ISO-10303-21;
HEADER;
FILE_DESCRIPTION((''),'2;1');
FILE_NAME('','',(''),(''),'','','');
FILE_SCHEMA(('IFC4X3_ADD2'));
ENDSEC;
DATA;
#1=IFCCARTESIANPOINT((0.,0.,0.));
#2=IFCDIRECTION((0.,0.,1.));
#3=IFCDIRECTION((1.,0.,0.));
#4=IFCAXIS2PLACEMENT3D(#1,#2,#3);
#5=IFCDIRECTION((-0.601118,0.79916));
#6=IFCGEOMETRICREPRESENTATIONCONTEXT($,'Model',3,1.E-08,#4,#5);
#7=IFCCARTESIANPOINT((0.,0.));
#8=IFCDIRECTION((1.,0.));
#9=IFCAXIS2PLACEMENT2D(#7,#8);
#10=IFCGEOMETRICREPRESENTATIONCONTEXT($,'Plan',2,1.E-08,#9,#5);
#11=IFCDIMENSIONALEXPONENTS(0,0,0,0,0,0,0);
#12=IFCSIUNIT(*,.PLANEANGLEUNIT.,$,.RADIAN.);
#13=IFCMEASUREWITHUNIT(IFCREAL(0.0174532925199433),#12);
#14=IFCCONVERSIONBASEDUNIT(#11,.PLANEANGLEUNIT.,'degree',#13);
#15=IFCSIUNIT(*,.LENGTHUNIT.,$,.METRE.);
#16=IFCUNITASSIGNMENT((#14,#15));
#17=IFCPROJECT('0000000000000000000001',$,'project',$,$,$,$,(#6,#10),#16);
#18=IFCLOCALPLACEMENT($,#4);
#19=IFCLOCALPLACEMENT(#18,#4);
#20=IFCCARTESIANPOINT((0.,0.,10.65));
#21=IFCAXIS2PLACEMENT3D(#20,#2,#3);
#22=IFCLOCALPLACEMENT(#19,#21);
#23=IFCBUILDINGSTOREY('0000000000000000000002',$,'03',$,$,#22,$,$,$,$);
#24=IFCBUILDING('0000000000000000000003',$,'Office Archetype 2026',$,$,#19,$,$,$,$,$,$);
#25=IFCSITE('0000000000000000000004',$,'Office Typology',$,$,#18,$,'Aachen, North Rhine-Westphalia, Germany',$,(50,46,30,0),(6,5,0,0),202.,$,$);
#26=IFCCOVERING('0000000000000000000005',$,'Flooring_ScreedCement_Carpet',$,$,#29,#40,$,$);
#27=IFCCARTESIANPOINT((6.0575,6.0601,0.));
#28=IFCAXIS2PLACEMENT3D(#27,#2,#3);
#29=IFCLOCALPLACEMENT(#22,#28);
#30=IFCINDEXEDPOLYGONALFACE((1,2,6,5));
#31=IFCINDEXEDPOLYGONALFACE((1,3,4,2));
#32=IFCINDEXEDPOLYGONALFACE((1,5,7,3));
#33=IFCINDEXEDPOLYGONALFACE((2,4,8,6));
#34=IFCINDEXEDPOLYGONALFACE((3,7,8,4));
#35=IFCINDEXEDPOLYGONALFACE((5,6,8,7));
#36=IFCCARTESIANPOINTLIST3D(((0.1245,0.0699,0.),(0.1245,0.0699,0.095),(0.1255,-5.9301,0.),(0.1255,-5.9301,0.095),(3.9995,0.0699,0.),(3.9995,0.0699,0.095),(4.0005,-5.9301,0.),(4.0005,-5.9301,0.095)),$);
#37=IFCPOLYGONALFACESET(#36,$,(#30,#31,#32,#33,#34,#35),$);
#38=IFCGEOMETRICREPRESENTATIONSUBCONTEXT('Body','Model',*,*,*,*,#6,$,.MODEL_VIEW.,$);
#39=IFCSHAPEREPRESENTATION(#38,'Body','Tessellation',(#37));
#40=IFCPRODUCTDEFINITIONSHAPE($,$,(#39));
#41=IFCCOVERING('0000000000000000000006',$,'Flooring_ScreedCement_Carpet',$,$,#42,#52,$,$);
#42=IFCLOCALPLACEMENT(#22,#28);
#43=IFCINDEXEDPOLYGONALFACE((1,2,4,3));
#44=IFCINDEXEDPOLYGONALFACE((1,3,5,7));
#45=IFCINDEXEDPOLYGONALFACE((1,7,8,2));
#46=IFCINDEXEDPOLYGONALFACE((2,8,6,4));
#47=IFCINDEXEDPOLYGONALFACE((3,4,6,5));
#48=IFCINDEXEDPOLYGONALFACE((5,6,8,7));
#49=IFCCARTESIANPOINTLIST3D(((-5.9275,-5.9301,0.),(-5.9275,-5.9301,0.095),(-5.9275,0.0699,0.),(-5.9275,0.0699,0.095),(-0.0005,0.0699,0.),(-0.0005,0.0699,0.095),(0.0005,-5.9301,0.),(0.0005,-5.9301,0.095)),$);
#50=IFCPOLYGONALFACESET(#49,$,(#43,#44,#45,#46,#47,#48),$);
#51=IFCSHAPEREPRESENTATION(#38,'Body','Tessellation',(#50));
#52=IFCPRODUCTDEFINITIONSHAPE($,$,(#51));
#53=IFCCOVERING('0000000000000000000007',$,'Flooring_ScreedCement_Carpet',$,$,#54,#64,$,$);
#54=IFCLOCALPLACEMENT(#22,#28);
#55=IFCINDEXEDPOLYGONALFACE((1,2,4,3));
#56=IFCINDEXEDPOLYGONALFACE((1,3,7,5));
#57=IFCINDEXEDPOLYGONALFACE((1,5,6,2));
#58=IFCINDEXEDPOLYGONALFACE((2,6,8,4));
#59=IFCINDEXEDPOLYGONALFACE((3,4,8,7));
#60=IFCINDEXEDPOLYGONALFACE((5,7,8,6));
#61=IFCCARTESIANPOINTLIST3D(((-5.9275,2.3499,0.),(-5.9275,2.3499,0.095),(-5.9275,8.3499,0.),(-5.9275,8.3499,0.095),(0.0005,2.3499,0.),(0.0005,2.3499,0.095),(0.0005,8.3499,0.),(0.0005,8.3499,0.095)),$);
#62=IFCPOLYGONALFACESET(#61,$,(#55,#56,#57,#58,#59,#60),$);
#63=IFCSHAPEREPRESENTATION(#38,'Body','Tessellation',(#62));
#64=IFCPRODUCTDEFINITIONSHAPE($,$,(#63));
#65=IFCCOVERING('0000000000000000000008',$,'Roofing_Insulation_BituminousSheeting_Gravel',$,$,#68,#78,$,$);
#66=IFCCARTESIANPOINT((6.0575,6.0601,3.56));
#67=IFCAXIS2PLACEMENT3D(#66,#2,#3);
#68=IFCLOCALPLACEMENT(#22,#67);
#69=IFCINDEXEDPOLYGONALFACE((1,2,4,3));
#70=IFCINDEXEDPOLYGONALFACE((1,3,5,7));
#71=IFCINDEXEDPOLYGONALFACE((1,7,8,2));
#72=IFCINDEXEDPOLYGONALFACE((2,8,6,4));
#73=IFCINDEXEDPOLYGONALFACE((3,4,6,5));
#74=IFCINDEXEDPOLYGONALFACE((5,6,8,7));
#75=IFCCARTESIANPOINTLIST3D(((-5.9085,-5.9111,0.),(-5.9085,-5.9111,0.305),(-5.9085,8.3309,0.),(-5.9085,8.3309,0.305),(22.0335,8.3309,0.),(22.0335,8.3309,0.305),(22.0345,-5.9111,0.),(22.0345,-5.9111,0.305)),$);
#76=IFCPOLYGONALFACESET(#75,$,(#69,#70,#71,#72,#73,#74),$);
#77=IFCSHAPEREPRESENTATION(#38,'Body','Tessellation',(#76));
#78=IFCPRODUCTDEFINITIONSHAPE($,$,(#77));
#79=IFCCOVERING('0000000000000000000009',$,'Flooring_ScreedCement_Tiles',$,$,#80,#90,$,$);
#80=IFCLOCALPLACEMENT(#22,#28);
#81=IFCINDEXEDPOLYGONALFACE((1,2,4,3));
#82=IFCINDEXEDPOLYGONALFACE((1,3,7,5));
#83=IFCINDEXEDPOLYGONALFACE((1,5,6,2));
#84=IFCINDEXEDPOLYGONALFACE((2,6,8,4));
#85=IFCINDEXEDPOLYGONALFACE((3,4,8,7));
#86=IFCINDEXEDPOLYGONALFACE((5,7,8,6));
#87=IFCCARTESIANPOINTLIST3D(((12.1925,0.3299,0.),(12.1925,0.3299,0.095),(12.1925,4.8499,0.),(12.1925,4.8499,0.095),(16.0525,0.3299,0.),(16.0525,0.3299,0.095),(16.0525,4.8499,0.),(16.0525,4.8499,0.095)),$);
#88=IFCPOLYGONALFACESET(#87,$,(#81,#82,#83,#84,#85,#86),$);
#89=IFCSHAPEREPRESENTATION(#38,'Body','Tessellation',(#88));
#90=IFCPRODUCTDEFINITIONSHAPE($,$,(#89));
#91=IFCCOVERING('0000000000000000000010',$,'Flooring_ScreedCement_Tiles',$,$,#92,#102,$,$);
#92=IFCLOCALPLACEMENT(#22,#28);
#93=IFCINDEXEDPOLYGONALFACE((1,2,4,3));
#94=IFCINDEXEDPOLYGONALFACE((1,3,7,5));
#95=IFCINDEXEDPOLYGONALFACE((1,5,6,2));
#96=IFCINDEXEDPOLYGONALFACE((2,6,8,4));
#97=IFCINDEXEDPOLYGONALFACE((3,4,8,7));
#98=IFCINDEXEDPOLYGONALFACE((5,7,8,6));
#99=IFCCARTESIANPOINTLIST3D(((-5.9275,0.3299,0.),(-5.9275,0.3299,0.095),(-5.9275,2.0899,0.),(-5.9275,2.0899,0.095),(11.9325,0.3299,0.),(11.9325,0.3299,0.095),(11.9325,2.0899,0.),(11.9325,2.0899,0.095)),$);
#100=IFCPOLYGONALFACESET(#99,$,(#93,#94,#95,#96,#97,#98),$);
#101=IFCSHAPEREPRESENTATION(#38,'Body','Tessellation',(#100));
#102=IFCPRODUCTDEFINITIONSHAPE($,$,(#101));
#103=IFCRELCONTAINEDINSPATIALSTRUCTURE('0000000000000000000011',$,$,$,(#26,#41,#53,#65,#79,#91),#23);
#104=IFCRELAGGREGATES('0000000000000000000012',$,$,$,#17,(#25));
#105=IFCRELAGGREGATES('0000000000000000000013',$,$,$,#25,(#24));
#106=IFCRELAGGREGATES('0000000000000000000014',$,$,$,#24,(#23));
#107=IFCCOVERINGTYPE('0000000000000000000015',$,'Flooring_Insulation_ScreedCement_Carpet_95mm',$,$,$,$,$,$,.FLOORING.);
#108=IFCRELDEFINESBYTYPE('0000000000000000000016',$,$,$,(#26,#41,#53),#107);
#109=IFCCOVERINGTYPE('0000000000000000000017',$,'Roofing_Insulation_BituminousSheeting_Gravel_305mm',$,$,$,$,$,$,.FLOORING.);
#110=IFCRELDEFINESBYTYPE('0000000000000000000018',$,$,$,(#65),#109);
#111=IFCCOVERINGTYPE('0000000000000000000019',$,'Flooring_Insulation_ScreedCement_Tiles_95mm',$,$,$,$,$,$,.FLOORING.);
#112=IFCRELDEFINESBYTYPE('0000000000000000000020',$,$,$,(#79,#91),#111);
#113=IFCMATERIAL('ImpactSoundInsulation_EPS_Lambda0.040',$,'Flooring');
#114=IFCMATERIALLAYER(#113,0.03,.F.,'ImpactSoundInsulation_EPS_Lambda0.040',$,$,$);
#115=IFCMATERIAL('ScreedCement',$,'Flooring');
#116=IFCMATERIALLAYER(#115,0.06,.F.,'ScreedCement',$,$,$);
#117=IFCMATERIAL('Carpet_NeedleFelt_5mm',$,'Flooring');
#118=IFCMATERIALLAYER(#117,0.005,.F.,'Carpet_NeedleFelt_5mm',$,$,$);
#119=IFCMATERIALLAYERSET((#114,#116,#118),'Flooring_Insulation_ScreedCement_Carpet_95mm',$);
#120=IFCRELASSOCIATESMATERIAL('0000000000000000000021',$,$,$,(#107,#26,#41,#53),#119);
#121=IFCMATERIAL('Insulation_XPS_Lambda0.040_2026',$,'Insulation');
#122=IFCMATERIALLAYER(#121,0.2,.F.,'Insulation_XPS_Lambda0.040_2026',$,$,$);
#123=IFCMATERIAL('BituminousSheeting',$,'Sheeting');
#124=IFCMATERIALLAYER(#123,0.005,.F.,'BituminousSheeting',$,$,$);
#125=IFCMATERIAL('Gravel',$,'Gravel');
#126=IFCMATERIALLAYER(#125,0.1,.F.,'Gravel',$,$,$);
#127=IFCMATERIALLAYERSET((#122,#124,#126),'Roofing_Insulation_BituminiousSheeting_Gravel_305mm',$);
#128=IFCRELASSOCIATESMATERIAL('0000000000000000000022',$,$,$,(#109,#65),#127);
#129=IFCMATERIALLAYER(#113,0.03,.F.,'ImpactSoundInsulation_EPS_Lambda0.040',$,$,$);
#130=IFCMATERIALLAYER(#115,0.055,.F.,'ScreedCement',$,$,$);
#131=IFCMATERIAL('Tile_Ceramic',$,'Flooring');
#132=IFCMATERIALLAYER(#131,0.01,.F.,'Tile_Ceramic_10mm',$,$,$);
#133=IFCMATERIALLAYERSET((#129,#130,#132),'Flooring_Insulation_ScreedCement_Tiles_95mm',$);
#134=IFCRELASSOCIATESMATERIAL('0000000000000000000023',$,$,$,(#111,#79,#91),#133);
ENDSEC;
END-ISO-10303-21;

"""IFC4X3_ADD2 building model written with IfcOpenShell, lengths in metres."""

from ifc_helpers import new_model, entity, si_unit, converted_unit, direction, frame, origin_with_axes, origin_2d_with_axis, place, context, subcontext, project, spatial, line, indexed_curve, outline, extrude, material, layer, layer_set, layer_usage, type_object, element, save


model = new_model("IFC4X3_ADD2")

# Units and contexts
model_context = context("Model", 3, precision=1e-08, world=origin_with_axes(), true_north=direction((-0.601118, 0.79916)))
plan_context = context("Plan", 2, precision=1e-08, world=origin_2d_with_axis(), true_north=direction((-0.601118, 0.79916)))
body_context = subcontext(model_context, "Body", "Model", "MODEL_VIEW")
ifc_project = project(units=[converted_unit("PLANEANGLEUNIT", "degree", entity("IfcReal", 0.0174532925199433), si_unit("PLANEANGLEUNIT", "RADIAN"), dimensions=[0, 0, 0, 0, 0, 0, 0]), si_unit("LENGTHUNIT", "METRE")], contexts=[model_context, plan_context])

# Site, building, storey
site_placement = place(None, origin_with_axes())
site = spatial("IfcSite", under=ifc_project, at=site_placement, Name="Office Typology", LongName="Aachen, North Rhine-Westphalia, Germany", RefLatitude=(50, 46, 30, 0), RefLongitude=(6, 5, 0, 0), RefElevation=202.0)
building_placement = place(site_placement, origin_with_axes())
building = spatial("IfcBuilding", under=site, at=building_placement, Name="Office Archetype 2026")
storey_placement = place(building_placement, frame((0.0, 0.0, 10.65), z_axis=(0.0, 0.0, 1.0), x_axis=(1.0, 0.0, 0.0)))
storey = spatial("IfcBuildingStorey", under=building, at=storey_placement, Name="03")

# Coverings
ifc_material_1 = material(Name="ImpactSoundInsulation_EPS_Lambda0.040", Category="Flooring")
ifc_layer_1 = layer(ifc_material_1, 0.03, ventilated=False, Name="ImpactSoundInsulation_EPS_Lambda0.040")
ifc_material_2 = material(Name="ScreedCement", Category="Flooring")
ifc_layer_2 = layer(ifc_material_2, 0.06, ventilated=False, Name="ScreedCement")
ifc_material_3 = material(Name="Carpet_NeedleFelt_5mm", Category="Flooring")
ifc_layer_3 = layer(ifc_material_3, 0.005, ventilated=False, Name="Carpet_NeedleFelt_5mm")
ifc_layer_set_1 = layer_set([ifc_layer_1, ifc_layer_2, ifc_layer_3], Name="Flooring_Insulation_ScreedCement_Carpet_95mm")
ifc_layer_usage_1 = layer_usage(ifc_layer_set_1, "AXIS3", "POSITIVE", 0.0)
covering_type_1 = type_object("IfcCoveringType", Name="Flooring_Insulation_ScreedCement_Carpet_95mm", PredefinedType="FLOORING", material=ifc_layer_set_1)
covering_1_placement = place(storey_placement, frame((6.0575, 6.0601, 0.0), z_axis=(0.0, 0.0, 1.0), x_axis=(1.0, 0.0, 0.0)))
element("IfcCovering", 1, at=covering_1_placement, inside=storey, type_object=covering_type_1, material=ifc_layer_usage_1, Name="Flooring_ScreedCement_Carpet", context=body_context, shape_type="SweptSolid", body=[
    extrude(outline(indexed_curve([(0.1255, -5.9301), (0.1245, 0.0699), (3.9995, 0.0699), (4.0005, -5.9301)], segments=[line(1, 2, 3, 4, 1)])), origin_with_axes(), (0.0, 0.0, 1.0), 0.095),
])
ifc_layer_usage_2 = layer_usage(ifc_layer_set_1, "AXIS3", "POSITIVE", 0.0)
covering_2_placement = place(storey_placement, frame((6.0575, 6.0601, 0.0), z_axis=(0.0, 0.0, 1.0), x_axis=(1.0, 0.0, 0.0)))
element("IfcCovering", 2, at=covering_2_placement, inside=storey, type_object=covering_type_1, material=ifc_layer_usage_2, Name="Flooring_ScreedCement_Carpet", context=body_context, shape_type="SweptSolid", body=[
    extrude(outline(indexed_curve([(-5.9275, -5.9301), (-5.9275, 0.0699), (-0.0005, 0.0699), (0.0005, -5.9301)], segments=[line(1, 2, 3, 4, 1)])), origin_with_axes(), (0.0, 0.0, 1.0), 0.095),
])
ifc_layer_usage_3 = layer_usage(ifc_layer_set_1, "AXIS3", "POSITIVE", 0.0)
covering_3_placement = place(storey_placement, frame((6.0575, 6.0601, 0.0), z_axis=(0.0, 0.0, 1.0), x_axis=(1.0, 0.0, 0.0)))
element("IfcCovering", 3, at=covering_3_placement, inside=storey, type_object=covering_type_1, material=ifc_layer_usage_3, Name="Flooring_ScreedCement_Carpet", context=body_context, shape_type="SweptSolid", body=[
    extrude(outline(indexed_curve([(0.0005, 2.3499), (-5.9275, 2.3499), (-5.9275, 8.3499), (0.0005, 8.3499), (0.0005, 2.3499)], segments=[line(1, 2, 3, 4, 5, 1)])), origin_with_axes(), (0.0, 0.0, 1.0), 0.095),
])
ifc_material_4 = material(Name="Insulation_XPS_Lambda0.040_2026", Category="Insulation")
ifc_layer_4 = layer(ifc_material_4, 0.2, ventilated=False, Name="Insulation_XPS_Lambda0.040_2026")
ifc_material_5 = material(Name="BituminousSheeting", Category="Sheeting")
ifc_layer_5 = layer(ifc_material_5, 0.005, ventilated=False, Name="BituminousSheeting")
ifc_material_6 = material(Name="Gravel", Category="Gravel")
ifc_layer_6 = layer(ifc_material_6, 0.1, ventilated=False, Name="Gravel")
ifc_layer_set_2 = layer_set([ifc_layer_4, ifc_layer_5, ifc_layer_6], Name="Roofing_Insulation_BituminiousSheeting_Gravel_305mm")
ifc_layer_usage_4 = layer_usage(ifc_layer_set_2, "AXIS3", "POSITIVE", 0.0)
covering_type_2 = type_object("IfcCoveringType", Name="Roofing_Insulation_BituminousSheeting_Gravel_305mm", PredefinedType="FLOORING", material=ifc_layer_set_2)
covering_4_placement = place(storey_placement, frame((6.0575, 6.0601, 3.56), z_axis=(0.0, 0.0, 1.0), x_axis=(1.0, 0.0, 0.0)))
element("IfcCovering", 4, at=covering_4_placement, inside=storey, type_object=covering_type_2, material=ifc_layer_usage_4, Name="Roofing_Insulation_BituminousSheeting_Gravel", context=body_context, shape_type="SweptSolid", body=[
    extrude(outline(indexed_curve([(22.0345, -5.9111), (22.0335, 8.3309), (-5.9085, 8.3309), (-5.9085, -5.9111), (22.0345, -5.9111)])), None, (0.0, 0.0, 1.0), 0.305),
])
ifc_layer_7 = layer(ifc_material_1, 0.03, ventilated=False, Name="ImpactSoundInsulation_EPS_Lambda0.040")
ifc_layer_8 = layer(ifc_material_2, 0.055, ventilated=False, Name="ScreedCement")
ifc_material_7 = material(Name="Tile_Ceramic", Category="Flooring")
ifc_layer_9 = layer(ifc_material_7, 0.01, ventilated=False, Name="Tile_Ceramic_10mm")
ifc_layer_set_3 = layer_set([ifc_layer_7, ifc_layer_8, ifc_layer_9], Name="Flooring_Insulation_ScreedCement_Tiles_95mm")
ifc_layer_usage_5 = layer_usage(ifc_layer_set_3, "AXIS3", "POSITIVE", 0.0)
covering_type_3 = type_object("IfcCoveringType", Name="Flooring_Insulation_ScreedCement_Tiles_95mm", PredefinedType="FLOORING", material=ifc_layer_set_3)
covering_5_placement = place(storey_placement, frame((6.0575, 6.0601, 0.0), z_axis=(0.0, 0.0, 1.0), x_axis=(1.0, 0.0, 0.0)))
element("IfcCovering", 5, at=covering_5_placement, inside=storey, type_object=covering_type_3, material=ifc_layer_usage_5, Name="Flooring_ScreedCement_Tiles", context=body_context, shape_type="SweptSolid", body=[
    extrude(outline(indexed_curve([(16.0525, 0.3299), (12.1925, 0.3299), (12.1925, 4.8499), (16.0525, 4.8499), (16.0525, 0.3299)], segments=[line(1, 2, 3, 4, 5, 1)])), origin_with_axes(), (0.0, 0.0, 1.0), 0.095),
])
ifc_layer_usage_6 = layer_usage(ifc_layer_set_3, "AXIS3", "POSITIVE", 0.0)
covering_6_placement = place(storey_placement, frame((6.0575, 6.0601, 0.0), z_axis=(0.0, 0.0, 1.0), x_axis=(1.0, 0.0, 0.0)))
element("IfcCovering", 6, at=covering_6_placement, inside=storey, type_object=covering_type_3, material=ifc_layer_usage_6, Name="Flooring_ScreedCement_Tiles", context=body_context, shape_type="SweptSolid", body=[
    extrude(outline(indexed_curve([(-5.9275, 0.3299), (-5.9275, 2.0899), (11.9325, 2.0899), (11.9325, 0.3299)], segments=[line(1, 2, 3, 4, 1)])), None, (0.0, 0.0, 1.0), 0.095),
])

save(model, "model.ifc")
